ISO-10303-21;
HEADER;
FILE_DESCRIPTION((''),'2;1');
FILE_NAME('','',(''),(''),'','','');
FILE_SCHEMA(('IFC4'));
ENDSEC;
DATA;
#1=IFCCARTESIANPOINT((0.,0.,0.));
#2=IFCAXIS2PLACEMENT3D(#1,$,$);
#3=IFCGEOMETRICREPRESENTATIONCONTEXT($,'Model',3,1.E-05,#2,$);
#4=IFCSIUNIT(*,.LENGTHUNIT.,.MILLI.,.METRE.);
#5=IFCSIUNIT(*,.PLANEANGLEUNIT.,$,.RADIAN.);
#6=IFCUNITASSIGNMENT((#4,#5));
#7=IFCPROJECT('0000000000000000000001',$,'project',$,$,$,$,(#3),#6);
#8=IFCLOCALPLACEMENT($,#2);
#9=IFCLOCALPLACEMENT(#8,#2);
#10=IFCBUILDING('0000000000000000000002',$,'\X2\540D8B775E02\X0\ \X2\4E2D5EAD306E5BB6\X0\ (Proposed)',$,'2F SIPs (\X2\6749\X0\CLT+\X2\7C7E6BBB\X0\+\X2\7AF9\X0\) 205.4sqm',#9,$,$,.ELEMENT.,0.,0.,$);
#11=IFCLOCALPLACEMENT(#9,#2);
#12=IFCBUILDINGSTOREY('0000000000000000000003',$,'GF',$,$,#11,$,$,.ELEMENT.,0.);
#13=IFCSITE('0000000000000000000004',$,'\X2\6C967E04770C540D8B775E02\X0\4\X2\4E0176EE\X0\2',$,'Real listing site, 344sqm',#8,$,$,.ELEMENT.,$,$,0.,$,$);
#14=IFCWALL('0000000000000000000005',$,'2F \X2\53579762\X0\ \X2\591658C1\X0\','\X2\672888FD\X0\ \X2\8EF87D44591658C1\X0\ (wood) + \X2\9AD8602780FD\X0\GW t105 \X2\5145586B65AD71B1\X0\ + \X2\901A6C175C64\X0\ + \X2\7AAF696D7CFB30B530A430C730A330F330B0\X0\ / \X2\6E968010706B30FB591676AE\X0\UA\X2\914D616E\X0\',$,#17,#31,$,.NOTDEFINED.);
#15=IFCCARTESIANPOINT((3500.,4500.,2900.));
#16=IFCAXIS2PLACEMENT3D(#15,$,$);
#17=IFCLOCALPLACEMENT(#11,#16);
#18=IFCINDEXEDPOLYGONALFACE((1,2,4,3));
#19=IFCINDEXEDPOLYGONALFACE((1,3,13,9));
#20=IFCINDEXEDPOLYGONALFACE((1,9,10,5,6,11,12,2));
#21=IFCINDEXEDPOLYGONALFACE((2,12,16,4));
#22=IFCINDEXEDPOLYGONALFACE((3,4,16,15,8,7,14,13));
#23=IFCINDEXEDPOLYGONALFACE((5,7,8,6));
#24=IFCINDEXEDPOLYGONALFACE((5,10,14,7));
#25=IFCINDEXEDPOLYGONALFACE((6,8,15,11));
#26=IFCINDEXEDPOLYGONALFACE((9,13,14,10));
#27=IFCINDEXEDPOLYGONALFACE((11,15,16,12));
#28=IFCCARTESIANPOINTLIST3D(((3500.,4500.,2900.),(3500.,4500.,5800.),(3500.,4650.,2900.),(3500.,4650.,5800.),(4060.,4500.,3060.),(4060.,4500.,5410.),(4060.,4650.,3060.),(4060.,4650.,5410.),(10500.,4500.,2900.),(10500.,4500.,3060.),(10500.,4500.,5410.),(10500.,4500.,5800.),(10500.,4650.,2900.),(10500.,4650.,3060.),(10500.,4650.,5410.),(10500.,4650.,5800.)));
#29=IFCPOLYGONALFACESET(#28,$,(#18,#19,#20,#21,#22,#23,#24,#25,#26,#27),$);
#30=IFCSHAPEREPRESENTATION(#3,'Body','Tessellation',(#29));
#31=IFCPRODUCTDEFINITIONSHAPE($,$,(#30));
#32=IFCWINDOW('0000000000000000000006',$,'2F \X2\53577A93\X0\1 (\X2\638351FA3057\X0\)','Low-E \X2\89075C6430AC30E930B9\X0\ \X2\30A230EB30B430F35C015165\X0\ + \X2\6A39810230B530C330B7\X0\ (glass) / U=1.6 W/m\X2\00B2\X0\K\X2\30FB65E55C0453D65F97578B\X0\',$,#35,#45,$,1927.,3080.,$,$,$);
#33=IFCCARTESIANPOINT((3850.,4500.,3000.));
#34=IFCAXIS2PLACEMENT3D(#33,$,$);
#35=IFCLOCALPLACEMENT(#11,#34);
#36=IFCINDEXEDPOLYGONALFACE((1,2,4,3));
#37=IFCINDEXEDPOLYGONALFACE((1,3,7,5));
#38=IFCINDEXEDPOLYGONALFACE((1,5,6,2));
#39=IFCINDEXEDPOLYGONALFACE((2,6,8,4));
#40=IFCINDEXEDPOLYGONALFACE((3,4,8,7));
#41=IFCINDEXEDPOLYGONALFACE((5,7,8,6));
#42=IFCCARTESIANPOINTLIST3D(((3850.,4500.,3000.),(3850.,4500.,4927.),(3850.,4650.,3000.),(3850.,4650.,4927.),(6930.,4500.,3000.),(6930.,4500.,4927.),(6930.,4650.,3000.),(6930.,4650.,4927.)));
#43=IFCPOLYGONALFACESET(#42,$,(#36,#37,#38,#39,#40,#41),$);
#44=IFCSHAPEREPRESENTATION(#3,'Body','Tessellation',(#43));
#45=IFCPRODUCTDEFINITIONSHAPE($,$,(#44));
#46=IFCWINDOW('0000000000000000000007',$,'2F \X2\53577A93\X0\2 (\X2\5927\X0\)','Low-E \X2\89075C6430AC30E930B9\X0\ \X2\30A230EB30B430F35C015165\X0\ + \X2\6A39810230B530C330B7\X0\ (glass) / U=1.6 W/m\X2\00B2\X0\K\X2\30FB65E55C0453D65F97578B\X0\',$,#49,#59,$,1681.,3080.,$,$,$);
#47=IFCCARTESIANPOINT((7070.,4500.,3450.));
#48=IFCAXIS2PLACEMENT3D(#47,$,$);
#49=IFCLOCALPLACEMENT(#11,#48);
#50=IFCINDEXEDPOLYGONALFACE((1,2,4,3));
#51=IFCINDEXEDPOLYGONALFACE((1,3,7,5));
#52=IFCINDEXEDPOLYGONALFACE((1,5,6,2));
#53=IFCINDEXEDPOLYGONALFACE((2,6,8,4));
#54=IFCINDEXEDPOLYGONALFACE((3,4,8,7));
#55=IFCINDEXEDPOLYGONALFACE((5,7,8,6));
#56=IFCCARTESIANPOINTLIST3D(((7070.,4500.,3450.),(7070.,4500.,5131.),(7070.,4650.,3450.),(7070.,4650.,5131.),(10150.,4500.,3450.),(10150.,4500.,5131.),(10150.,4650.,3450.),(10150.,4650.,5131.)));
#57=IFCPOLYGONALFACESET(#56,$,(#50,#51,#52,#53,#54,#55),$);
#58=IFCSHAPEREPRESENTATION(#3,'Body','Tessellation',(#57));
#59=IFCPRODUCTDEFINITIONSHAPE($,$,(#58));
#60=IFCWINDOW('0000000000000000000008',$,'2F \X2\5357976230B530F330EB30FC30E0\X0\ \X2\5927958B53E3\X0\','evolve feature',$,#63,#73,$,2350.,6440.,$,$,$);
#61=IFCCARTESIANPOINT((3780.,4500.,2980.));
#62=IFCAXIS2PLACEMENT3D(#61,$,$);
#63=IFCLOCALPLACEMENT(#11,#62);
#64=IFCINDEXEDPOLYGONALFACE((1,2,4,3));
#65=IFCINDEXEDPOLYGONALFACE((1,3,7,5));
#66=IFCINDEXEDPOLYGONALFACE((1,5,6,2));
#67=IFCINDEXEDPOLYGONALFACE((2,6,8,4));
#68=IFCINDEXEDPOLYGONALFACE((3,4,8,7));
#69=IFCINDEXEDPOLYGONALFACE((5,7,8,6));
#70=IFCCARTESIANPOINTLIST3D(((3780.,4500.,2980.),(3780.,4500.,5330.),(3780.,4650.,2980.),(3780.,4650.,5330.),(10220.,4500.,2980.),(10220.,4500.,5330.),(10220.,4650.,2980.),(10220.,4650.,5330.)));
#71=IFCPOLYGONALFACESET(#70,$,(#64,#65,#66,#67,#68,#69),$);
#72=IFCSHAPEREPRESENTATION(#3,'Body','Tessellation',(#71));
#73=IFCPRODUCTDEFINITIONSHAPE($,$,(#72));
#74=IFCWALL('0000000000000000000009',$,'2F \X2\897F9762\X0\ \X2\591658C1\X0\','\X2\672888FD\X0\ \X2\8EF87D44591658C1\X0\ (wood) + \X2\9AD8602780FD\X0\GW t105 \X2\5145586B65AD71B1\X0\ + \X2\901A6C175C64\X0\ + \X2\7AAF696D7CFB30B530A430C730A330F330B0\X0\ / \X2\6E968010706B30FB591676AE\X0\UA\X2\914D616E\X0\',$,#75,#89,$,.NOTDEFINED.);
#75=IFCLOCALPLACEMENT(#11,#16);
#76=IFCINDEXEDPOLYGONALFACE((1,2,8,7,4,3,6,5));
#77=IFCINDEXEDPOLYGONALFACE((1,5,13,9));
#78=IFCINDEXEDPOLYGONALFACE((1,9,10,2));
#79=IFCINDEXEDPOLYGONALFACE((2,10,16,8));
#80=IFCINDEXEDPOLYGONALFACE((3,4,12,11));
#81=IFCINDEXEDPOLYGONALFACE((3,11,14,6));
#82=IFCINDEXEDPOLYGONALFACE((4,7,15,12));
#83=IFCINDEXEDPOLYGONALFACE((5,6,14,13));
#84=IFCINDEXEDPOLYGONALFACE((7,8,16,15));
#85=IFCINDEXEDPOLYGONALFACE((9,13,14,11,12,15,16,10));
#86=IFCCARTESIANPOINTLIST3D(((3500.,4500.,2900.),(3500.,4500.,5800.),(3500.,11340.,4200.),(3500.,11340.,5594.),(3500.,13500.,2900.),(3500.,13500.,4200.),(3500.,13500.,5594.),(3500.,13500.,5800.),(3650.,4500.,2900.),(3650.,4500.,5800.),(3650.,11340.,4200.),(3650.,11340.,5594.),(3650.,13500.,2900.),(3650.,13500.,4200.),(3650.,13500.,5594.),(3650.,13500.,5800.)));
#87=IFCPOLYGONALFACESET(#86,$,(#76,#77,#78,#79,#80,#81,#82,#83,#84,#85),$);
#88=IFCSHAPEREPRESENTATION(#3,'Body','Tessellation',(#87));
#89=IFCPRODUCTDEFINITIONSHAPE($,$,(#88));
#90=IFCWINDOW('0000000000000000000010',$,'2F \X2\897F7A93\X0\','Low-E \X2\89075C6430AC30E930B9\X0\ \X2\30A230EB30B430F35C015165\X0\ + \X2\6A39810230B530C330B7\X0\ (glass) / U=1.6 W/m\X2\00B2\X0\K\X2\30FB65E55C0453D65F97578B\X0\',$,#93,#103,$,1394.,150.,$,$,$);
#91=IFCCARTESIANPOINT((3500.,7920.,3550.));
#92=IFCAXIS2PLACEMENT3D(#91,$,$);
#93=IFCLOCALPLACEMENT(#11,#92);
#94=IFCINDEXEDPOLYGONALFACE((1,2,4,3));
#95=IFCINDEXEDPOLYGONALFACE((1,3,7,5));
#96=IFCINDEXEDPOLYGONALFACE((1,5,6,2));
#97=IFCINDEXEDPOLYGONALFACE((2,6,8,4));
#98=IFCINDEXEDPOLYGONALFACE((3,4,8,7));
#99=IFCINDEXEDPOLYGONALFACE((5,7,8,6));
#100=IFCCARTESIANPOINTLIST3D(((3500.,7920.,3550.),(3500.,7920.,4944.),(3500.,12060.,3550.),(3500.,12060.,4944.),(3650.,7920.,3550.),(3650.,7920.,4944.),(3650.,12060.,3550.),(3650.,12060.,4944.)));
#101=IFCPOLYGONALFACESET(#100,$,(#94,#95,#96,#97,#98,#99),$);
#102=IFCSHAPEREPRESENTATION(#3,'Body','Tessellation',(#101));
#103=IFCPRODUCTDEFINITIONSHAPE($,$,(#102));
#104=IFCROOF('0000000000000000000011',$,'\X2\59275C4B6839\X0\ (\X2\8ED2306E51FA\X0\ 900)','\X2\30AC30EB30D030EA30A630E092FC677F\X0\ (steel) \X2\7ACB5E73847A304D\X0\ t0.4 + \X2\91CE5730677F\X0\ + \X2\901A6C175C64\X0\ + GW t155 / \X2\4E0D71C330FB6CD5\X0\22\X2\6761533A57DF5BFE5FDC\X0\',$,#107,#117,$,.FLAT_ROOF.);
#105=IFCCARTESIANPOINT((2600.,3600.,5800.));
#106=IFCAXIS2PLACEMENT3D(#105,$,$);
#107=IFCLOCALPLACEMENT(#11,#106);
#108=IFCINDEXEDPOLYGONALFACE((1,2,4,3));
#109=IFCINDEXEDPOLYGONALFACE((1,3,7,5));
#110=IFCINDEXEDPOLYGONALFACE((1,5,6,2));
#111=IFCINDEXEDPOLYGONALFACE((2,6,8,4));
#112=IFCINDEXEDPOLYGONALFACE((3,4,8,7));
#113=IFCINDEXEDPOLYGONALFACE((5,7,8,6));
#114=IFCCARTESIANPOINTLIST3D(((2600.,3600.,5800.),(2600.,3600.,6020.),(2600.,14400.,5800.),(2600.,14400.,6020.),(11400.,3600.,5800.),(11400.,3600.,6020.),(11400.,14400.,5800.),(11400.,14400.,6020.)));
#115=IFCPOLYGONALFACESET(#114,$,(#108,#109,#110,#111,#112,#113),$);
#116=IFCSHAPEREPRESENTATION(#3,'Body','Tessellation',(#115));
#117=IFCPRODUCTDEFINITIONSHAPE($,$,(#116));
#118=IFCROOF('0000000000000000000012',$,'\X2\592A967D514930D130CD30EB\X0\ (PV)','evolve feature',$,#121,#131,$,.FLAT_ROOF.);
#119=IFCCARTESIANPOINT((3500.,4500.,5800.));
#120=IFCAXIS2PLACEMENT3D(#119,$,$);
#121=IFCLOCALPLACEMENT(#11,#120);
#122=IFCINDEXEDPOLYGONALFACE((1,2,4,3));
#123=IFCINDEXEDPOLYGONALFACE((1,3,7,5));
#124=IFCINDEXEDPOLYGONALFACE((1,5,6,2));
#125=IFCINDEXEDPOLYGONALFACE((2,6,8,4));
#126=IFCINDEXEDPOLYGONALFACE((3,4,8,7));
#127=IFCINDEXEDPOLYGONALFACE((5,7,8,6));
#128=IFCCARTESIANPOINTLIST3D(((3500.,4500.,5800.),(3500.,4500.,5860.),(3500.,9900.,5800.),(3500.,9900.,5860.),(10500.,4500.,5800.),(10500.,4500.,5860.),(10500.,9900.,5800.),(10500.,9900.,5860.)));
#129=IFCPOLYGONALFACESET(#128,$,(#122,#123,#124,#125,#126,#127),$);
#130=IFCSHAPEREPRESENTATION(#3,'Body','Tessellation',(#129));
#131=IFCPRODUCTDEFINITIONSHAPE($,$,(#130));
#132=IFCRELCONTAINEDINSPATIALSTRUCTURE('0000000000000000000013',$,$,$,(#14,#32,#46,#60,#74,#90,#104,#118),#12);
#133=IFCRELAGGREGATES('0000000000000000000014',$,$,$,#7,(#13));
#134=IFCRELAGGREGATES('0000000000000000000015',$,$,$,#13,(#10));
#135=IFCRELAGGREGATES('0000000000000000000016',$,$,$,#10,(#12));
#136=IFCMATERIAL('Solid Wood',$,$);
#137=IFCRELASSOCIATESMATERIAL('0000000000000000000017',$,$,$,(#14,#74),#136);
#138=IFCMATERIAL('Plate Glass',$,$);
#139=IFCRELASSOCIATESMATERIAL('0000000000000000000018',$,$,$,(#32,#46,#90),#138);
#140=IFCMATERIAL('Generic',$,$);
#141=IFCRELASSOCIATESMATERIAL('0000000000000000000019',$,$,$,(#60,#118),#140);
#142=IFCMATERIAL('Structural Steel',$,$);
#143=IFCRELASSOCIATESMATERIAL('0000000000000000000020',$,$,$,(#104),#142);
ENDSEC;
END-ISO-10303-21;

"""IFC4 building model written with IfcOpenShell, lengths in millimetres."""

from ifc_helpers import new_model, si_unit, frame, frame_2d, origin, place, context, project, spatial, rectangle, extrude, material, element, fill, save


model = new_model("IFC4")

# Units and contexts
model_context = context("Model", 3, precision=1e-05, world=origin())
ifc_project = project(units=[si_unit("LENGTHUNIT", "METRE", prefix="MILLI"), si_unit("PLANEANGLEUNIT", "RADIAN")], contexts=[model_context])

# Site, building, storey
site_placement = place(None, origin())
site = spatial("IfcSite", under=ifc_project, at=site_placement, Name="沖縄県名護市4丁目2", ObjectType="Real listing site, 344sqm", CompositionType="ELEMENT", RefElevation=0.0)
building_placement = place(site_placement, origin())
building = spatial("IfcBuilding", under=site, at=building_placement, Name="名護市 中庭の家 (Proposed)", ObjectType="2F SIPs (杉CLT+籾殻+竹) 205.4sqm", CompositionType="ELEMENT", ElevationOfRefHeight=0.0, ElevationOfTerrain=0.0)
storey_placement = place(building_placement, origin())
storey = spatial("IfcBuildingStorey", under=building, at=storey_placement, Name="GF", CompositionType="ELEMENT", Elevation=0.0)

# Shared definitions
ifc_material_1 = material(Name="Solid Wood")
ifc_material_2 = material(Name="Generic")

# Shared definitions
ifc_material_3 = material(Name="Plate Glass")

# Wall, openings, windows
wall_1_placement = place(storey_placement, frame((3500.0, 4500.0, 2900.0)))
wall_1 = element("IfcWall", 1, at=wall_1_placement, inside=storey, material=ifc_material_1, Name="2F 南面 外壁", Description="木製 軸組外壁 (wood) + 高性能GW t105 充填断熱 + 通気層 + 窯業系サイディング / 準耐火・外皮UA配慮", PredefinedType="NOTDEFINED", context=model_context, shape_type="SweptSolid", body=[
    extrude(rectangle(XDim=7000.0, YDim=150.0, at=frame_2d((3500.0, 75.0))), frame((3500.0, 4500.0, 2900.0)), (0.0, 0.0, 1.0), 2900.0),
])
opening_1_placement = place(storey_placement, frame((3850.0, 4500.0, 3000.0)))
opening_1 = element("IfcOpeningElement", 2, at=opening_1_placement, cuts=wall_1, PredefinedType="NOTDEFINED", context=model_context, shape_type="SweptSolid", body=[
    extrude(rectangle(XDim=3080.0, YDim=150.0, at=frame_2d((1540.0, 75.0))), frame((3850.0, 4500.0, 3000.0)), (0.0, 0.0, 1.0), 1927.0),
])
opening_2_placement = place(storey_placement, frame((7070.0, 4500.0, 3450.0)))
opening_2 = element("IfcOpeningElement", 3, at=opening_2_placement, cuts=wall_1, PredefinedType="NOTDEFINED", context=model_context, shape_type="SweptSolid", body=[
    extrude(rectangle(XDim=3080.0, YDim=150.0, at=frame_2d((1540.0, 75.0))), frame((7070.0, 4500.0, 3450.0)), (0.0, 0.0, 1.0), 1681.0),
])
opening_3_placement = place(storey_placement, frame((3780.0, 4500.0, 2980.0)))
opening_3 = element("IfcOpeningElement", 4, at=opening_3_placement, cuts=wall_1, PredefinedType="NOTDEFINED", context=model_context, shape_type="SweptSolid", body=[
    extrude(rectangle(XDim=6440.0, YDim=150.0, at=frame_2d((3220.0, 75.0))), frame((3780.0, 4500.0, 2980.0)), (0.0, 0.0, 1.0), 2350.0),
])
window_1_placement = place(storey_placement, frame((3850.0, 4500.0, 3000.0)))
window_1 = element("IfcWindow", 5, at=window_1_placement, inside=storey, material=ifc_material_3, Name="2F 南窓1 (掃出し)", Description="Low-E 複層ガラス アルゴン封入 + 樹脂サッシ (glass) / U=1.6 W/m²K・日射取得型", OverallHeight=1927.0, OverallWidth=3080.0, context=model_context, shape_type="SweptSolid", body=[
    extrude(rectangle(XDim=3080.0, YDim=150.0, at=frame_2d((1540.0, 75.0))), frame((3850.0, 4500.0, 3000.0)), (0.0, 0.0, 1.0), 1927.0),
])
fill(opening_1, window_1)
window_2_placement = place(storey_placement, frame((7070.0, 4500.0, 3450.0)))
window_2 = element("IfcWindow", 6, at=window_2_placement, inside=storey, material=ifc_material_3, Name="2F 南窓2 (大)", Description="Low-E 複層ガラス アルゴン封入 + 樹脂サッシ (glass) / U=1.6 W/m²K・日射取得型", OverallHeight=1681.0, OverallWidth=3080.0, context=model_context, shape_type="SweptSolid", body=[
    extrude(rectangle(XDim=3080.0, YDim=150.0, at=frame_2d((1540.0, 75.0))), frame((7070.0, 4500.0, 3450.0)), (0.0, 0.0, 1.0), 1681.0),
])
fill(opening_2, window_2)
window_3_placement = place(storey_placement, frame((3780.0, 4500.0, 2980.0)))
window_3 = element("IfcWindow", 7, at=window_3_placement, inside=storey, material=ifc_material_2, Name="2F 南面サンルーム 大開口", Description="evolve feature", OverallHeight=2350.0, OverallWidth=6440.0, context=model_context, shape_type="SweptSolid", body=[
    extrude(rectangle(XDim=6440.0, YDim=150.0, at=frame_2d((3220.0, 75.0))), frame((3780.0, 4500.0, 2980.0)), (0.0, 0.0, 1.0), 2350.0),
])
fill(opening_3, window_3)

# Wall, opening, window
wall_2_placement = place(storey_placement, frame((3500.0, 4500.0, 2900.0)))
wall_2 = element("IfcWall", 8, at=wall_2_placement, inside=storey, material=ifc_material_1, Name="2F 西面 外壁", Description="木製 軸組外壁 (wood) + 高性能GW t105 充填断熱 + 通気層 + 窯業系サイディング / 準耐火・外皮UA配慮", PredefinedType="NOTDEFINED", context=model_context, shape_type="SweptSolid", body=[
    extrude(rectangle(XDim=150.0, YDim=9000.0, at=frame_2d((75.0, 4500.0))), frame((3500.0, 4500.0, 2900.0)), (0.0, 0.0, 1.0), 2900.0),
])
opening_4_placement = place(storey_placement, frame((3500.0, 7920.0, 3550.0)))
opening_4 = element("IfcOpeningElement", 9, at=opening_4_placement, cuts=wall_2, PredefinedType="NOTDEFINED", context=model_context, shape_type="SweptSolid", body=[
    extrude(rectangle(XDim=150.0, YDim=4140.0, at=frame_2d((75.0, 2070.0))), frame((3500.0, 7920.0, 3550.0)), (0.0, 0.0, 1.0), 1394.0),
])
window_4_placement = place(storey_placement, frame((3500.0, 7920.0, 3550.0)))
window_4 = element("IfcWindow", 10, at=window_4_placement, inside=storey, material=ifc_material_3, Name="2F 西窓", Description="Low-E 複層ガラス アルゴン封入 + 樹脂サッシ (glass) / U=1.6 W/m²K・日射取得型", OverallHeight=1394.0, OverallWidth=150.0, context=model_context, shape_type="SweptSolid", body=[
    extrude(rectangle(XDim=150.0, YDim=4140.0, at=frame_2d((75.0, 2070.0))), frame((3500.0, 7920.0, 3550.0)), (0.0, 0.0, 1.0), 1394.0),
])
fill(opening_4, window_4)

# Roofs
ifc_material_4 = material(Name="Structural Steel")
roof_1_placement = place(storey_placement, frame((2600.0, 3600.0, 5800.0)))
element("IfcRoof", 11, at=roof_1_placement, inside=storey, material=ifc_material_4, Name="大屋根 (軒の出 900)", Description="ガルバリウム鋼板 (steel) 立平葺き t0.4 + 野地板 + 通気層 + GW t155 / 不燃・法22条区域対応", PredefinedType="FLAT_ROOF", context=model_context, shape_type="SweptSolid", body=[
    extrude(rectangle(XDim=8800.0, YDim=10800.0, at=frame_2d((4400.0, 5400.0))), frame((2600.0, 3600.0, 5800.0)), (0.0, 0.0, 1.0), 220.0),
])
roof_2_placement = place(storey_placement, frame((3500.0, 4500.0, 5800.0)))
element("IfcRoof", 12, at=roof_2_placement, inside=storey, material=ifc_material_2, Name="太陽光パネル (PV)", Description="evolve feature", PredefinedType="FLAT_ROOF", context=model_context, shape_type="SweptSolid", body=[
    extrude(rectangle(XDim=7000.0, YDim=5400.0, at=frame_2d((3500.0, 2700.0))), frame((3500.0, 4500.0, 5800.0)), (0.0, 0.0, 1.0), 60.0),
])

save(model, "model.ifc")
